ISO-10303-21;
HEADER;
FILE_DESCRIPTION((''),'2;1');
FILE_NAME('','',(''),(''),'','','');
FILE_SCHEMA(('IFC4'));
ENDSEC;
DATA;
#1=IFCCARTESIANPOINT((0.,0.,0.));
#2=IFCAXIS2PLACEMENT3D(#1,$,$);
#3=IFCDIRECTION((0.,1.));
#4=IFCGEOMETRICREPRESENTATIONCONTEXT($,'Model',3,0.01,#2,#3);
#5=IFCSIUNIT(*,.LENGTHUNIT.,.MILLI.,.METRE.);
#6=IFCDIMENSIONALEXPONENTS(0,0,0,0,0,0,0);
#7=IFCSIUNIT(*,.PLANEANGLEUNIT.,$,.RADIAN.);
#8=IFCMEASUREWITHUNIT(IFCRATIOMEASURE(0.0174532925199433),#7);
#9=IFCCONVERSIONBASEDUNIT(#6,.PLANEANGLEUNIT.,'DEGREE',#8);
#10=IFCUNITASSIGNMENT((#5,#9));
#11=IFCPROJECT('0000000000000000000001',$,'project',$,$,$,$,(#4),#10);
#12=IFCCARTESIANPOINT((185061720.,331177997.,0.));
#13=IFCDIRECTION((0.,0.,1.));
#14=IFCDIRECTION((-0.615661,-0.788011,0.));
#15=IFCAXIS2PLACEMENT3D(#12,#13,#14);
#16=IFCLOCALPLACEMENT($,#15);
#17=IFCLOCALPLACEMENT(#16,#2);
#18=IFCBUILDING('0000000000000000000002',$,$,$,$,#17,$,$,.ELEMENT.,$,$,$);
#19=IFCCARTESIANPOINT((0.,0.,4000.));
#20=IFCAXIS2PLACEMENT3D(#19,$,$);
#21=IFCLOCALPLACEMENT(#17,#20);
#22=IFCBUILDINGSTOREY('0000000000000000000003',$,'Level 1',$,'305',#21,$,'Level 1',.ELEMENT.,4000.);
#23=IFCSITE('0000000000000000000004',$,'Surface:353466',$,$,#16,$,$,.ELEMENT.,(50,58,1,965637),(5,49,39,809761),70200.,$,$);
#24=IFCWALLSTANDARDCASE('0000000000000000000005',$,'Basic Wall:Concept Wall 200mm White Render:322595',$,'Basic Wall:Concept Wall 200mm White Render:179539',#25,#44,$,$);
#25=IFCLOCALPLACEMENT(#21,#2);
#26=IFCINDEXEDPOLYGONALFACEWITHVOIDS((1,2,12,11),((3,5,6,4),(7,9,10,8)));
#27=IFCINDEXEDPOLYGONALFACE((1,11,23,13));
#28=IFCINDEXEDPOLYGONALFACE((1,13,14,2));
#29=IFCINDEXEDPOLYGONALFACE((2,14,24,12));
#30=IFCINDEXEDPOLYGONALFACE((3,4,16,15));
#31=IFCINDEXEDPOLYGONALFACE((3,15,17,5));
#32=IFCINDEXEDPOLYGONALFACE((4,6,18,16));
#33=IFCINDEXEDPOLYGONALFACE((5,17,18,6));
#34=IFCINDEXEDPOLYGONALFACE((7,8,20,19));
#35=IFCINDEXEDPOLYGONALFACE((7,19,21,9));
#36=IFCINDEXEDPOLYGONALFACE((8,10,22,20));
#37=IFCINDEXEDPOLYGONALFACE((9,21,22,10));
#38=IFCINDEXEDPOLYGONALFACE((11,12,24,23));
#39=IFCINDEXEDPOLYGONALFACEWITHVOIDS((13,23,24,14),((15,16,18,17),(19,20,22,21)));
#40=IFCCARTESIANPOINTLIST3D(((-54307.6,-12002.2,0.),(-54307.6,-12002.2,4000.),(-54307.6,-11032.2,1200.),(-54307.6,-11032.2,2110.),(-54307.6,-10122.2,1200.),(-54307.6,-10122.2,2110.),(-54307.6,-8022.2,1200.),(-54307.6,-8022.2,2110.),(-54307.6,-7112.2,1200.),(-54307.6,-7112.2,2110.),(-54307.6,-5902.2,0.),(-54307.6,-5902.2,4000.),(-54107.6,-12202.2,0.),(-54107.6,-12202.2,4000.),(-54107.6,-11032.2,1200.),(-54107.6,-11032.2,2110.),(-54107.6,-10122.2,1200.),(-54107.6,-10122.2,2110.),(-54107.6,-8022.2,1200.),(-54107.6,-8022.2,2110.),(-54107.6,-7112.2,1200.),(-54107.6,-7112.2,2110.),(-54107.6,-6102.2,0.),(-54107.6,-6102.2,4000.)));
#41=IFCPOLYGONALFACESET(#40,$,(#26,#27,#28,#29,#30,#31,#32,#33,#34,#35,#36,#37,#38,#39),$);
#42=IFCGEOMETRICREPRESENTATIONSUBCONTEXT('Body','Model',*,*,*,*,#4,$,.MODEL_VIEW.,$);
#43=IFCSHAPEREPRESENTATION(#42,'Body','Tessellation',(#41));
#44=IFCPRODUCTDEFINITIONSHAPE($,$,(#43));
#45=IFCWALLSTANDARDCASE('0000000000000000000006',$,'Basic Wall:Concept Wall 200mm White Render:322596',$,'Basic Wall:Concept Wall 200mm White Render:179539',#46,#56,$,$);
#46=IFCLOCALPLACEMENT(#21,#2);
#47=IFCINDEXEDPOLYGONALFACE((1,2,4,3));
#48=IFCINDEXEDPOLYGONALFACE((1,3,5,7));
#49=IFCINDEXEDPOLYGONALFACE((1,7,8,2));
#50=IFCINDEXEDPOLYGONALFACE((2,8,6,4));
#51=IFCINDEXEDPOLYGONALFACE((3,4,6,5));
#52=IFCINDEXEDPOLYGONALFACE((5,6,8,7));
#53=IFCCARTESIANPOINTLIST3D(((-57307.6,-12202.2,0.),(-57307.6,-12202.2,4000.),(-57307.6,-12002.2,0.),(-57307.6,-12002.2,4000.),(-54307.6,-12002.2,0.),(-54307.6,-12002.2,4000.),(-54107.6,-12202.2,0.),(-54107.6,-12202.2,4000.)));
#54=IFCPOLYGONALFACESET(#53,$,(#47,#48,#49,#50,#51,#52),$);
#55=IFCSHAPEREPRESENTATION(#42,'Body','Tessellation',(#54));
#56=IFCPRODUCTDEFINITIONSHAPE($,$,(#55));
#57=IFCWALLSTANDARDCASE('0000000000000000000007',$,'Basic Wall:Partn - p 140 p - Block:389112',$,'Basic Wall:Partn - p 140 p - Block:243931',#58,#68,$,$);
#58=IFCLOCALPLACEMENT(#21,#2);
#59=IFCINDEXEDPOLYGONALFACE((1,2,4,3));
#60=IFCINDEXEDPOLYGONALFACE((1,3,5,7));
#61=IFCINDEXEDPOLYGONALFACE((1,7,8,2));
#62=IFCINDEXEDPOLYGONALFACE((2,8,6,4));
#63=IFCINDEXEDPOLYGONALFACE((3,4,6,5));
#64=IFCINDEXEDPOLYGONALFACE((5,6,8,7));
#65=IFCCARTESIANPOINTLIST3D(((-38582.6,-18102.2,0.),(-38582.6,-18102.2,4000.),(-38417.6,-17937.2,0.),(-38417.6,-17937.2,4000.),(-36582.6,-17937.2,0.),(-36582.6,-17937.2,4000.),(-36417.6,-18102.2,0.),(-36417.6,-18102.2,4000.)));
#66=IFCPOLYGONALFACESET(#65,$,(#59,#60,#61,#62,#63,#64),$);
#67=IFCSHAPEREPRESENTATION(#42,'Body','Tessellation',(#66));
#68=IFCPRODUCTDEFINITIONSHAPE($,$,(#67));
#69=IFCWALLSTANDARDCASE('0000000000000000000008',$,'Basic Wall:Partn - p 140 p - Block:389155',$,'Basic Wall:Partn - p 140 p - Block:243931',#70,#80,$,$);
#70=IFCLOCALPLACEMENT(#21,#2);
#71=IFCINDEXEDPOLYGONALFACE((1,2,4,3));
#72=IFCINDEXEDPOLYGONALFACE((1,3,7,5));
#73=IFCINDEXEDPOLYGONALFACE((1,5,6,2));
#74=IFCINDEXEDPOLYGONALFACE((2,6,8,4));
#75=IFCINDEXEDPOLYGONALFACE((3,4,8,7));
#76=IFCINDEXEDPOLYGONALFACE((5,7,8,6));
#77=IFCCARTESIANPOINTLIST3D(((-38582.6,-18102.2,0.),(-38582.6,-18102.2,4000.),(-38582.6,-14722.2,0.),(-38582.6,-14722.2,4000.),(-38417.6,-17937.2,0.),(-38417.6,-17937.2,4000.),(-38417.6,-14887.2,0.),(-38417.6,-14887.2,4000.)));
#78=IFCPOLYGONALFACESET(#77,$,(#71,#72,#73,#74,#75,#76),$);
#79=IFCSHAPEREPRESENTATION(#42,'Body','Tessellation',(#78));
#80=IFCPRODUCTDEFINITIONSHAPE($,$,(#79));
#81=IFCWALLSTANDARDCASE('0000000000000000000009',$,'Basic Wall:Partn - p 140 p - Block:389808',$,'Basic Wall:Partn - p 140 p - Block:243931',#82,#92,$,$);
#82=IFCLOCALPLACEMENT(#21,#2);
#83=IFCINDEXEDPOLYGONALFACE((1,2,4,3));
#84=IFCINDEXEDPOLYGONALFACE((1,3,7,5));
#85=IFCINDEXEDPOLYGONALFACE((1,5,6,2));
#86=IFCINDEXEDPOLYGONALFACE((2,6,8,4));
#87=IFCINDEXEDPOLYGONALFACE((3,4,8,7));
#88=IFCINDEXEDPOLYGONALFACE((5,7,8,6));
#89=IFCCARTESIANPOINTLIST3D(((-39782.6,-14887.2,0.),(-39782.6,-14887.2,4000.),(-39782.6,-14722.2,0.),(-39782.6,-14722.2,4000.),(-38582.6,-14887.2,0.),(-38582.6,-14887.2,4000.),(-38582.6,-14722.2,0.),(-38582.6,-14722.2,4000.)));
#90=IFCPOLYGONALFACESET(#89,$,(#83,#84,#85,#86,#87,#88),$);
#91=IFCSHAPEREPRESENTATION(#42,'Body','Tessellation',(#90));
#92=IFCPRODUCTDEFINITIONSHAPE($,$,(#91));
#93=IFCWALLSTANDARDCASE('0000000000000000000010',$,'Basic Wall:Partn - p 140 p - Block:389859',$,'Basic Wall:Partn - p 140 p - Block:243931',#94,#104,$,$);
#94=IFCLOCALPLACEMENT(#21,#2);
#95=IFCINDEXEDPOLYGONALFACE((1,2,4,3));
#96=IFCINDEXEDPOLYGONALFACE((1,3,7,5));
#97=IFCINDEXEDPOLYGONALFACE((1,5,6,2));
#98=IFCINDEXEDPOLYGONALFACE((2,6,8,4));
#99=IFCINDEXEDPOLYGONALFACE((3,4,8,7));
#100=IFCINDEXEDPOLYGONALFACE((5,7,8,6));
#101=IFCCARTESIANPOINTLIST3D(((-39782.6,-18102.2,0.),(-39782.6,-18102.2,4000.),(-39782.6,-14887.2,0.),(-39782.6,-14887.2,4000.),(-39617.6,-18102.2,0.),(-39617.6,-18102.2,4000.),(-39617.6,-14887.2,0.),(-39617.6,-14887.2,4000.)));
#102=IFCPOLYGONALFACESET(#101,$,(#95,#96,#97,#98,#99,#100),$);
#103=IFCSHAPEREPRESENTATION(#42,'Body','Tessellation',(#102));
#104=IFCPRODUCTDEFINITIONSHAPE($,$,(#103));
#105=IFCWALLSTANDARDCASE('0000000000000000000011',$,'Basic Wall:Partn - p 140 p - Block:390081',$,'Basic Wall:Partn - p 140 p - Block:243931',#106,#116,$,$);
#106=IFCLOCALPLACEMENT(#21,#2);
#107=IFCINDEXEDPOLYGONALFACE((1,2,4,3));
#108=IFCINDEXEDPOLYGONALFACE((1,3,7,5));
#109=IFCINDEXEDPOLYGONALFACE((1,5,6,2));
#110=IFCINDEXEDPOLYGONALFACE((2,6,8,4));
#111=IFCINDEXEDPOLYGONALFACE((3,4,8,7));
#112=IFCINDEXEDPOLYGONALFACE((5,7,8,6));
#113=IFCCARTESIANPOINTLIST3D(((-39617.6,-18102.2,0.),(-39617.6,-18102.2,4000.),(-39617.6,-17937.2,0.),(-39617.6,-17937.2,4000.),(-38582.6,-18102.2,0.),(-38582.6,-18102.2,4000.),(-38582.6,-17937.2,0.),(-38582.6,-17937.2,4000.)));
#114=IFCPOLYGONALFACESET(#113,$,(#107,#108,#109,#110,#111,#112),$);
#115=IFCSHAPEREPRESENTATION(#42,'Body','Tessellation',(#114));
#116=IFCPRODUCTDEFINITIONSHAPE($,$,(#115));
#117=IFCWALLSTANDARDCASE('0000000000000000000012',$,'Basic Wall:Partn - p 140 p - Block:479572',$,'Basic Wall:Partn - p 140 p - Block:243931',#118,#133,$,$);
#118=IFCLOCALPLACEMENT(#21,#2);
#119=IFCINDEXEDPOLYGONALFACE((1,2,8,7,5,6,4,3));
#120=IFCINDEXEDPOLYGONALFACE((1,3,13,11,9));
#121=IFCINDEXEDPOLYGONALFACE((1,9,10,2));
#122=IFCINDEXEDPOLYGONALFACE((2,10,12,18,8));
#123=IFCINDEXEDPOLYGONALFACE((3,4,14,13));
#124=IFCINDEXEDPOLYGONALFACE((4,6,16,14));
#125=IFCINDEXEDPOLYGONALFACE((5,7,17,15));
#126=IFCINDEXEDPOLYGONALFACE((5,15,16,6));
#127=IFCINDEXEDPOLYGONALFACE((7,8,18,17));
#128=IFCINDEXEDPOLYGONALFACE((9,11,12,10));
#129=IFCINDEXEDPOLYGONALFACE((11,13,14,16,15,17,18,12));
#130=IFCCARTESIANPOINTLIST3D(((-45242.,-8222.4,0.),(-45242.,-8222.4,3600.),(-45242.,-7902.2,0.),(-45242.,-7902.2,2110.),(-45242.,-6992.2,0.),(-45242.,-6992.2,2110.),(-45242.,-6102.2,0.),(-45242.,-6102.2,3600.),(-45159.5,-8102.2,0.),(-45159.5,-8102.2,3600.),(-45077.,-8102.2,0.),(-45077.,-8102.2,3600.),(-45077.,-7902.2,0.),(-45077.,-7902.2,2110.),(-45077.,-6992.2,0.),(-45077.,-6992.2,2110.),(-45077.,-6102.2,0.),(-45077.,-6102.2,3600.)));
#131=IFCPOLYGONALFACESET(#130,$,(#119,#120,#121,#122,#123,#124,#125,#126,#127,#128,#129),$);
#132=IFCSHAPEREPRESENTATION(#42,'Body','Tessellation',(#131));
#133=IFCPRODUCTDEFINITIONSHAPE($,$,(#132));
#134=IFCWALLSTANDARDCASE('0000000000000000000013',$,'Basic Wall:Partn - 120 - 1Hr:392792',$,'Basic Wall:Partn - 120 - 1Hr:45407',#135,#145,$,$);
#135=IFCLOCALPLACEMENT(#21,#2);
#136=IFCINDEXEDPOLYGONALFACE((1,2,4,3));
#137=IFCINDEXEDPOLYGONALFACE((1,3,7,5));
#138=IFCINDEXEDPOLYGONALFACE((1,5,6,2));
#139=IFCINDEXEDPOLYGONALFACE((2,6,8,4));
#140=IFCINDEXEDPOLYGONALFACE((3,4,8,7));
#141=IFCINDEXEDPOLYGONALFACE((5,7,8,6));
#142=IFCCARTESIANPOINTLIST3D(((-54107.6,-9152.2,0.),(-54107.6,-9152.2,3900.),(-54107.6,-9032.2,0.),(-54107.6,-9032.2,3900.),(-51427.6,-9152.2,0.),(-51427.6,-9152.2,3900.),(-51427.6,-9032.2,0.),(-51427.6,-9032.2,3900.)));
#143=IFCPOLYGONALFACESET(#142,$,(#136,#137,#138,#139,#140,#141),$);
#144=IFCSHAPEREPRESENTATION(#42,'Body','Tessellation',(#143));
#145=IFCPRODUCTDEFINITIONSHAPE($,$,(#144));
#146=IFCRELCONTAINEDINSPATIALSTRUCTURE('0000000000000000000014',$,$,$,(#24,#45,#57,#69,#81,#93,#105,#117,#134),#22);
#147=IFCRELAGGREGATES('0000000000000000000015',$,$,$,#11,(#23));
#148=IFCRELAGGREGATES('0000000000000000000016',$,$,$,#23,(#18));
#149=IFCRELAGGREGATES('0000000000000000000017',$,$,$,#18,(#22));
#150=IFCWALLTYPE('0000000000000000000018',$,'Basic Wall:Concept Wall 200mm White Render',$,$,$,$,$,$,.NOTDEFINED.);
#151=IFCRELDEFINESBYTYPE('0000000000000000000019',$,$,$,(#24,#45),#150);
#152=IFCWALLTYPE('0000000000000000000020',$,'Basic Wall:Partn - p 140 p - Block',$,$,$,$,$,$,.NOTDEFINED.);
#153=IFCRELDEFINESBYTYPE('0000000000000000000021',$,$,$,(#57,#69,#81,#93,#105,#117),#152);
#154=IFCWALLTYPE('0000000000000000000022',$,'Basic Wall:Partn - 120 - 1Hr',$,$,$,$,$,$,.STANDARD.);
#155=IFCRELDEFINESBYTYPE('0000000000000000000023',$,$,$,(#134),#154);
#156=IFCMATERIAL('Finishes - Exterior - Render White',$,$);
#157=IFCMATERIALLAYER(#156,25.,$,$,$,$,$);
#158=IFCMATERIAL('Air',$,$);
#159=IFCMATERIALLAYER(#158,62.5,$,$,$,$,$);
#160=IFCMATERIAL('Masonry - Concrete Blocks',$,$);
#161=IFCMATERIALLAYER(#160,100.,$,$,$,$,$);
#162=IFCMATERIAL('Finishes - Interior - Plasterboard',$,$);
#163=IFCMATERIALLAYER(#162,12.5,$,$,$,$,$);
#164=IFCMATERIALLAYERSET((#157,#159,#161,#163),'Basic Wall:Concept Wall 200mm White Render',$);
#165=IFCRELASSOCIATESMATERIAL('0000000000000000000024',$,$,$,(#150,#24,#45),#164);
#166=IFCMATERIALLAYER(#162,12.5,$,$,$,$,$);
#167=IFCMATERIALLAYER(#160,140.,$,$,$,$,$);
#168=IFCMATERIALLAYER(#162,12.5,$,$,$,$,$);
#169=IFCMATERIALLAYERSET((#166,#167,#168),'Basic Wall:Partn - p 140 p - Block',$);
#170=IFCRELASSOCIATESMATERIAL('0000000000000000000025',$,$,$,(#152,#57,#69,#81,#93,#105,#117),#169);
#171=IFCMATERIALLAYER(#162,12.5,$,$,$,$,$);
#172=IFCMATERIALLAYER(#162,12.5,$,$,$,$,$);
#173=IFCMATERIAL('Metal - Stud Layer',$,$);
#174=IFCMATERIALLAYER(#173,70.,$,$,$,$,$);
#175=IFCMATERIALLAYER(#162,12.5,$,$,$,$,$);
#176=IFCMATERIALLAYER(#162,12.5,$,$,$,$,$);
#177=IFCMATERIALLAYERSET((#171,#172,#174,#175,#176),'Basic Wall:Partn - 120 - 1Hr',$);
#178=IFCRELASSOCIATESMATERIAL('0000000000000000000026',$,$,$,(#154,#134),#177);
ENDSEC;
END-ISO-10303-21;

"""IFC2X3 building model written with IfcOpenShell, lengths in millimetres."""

from ifc_helpers import new_model, entity, si_unit, converted_unit, direction, frame, frame_2d, origin, place, context, subcontext, project, spatial, polyline, rectangle, outline, extrude, clip, halfspace, bounded_halfspace, material, layer, layer_set, layer_usage, type_object, element, save


model = new_model("IFC2X3")

# Units and contexts
model_context = context("Model", 3, precision=0.01, world=origin(), true_north=direction((0.0, 1.0)))
body_context = subcontext(model_context, "Body", "Model", "MODEL_VIEW")
ifc_project = project(units=[si_unit("LENGTHUNIT", "METRE", prefix="MILLI"), converted_unit("PLANEANGLEUNIT", "DEGREE", entity("IfcRatioMeasure", 0.0174532925199433), si_unit("PLANEANGLEUNIT", "RADIAN"), dimensions=[0, 0, 0, 0, 0, 0, 0])], contexts=[model_context])

# Site, building, storey
site_placement = place(None, frame((185061720.0, 331177997.0, 0.0), z_axis=(0.0, 0.0, 1.0), x_axis=(-0.615661, -0.788011, 0.0)))
site = spatial("IfcSite", under=ifc_project, at=site_placement, Name="Surface:353466", CompositionType="ELEMENT", RefLatitude=(50, 58, 1, 965637), RefLongitude=(5, 49, 39, 809761), RefElevation=70200.0)
building_placement = place(site_placement, origin())
building = spatial("IfcBuilding", under=site, at=building_placement, CompositionType="ELEMENT")
storey_placement = place(building_placement, frame((0.0, 0.0, 4000.0)))
storey = spatial("IfcBuildingStorey", under=building, at=storey_placement, Name="Level 1", ObjectType="305", LongName="Level 1", CompositionType="ELEMENT", Elevation=4000.0)

# Wall, openings
ifc_material_1 = material(Name="Finishes - Exterior - Render White")
ifc_layer_1 = layer(ifc_material_1, 25.0)
ifc_material_2 = material(Name="Air")
ifc_layer_2 = layer(ifc_material_2, 62.5)
ifc_material_3 = material(Name="Masonry - Concrete Blocks")
ifc_layer_3 = layer(ifc_material_3, 100.0)
ifc_material_4 = material(Name="Finishes - Interior - Plasterboard")
ifc_layer_4 = layer(ifc_material_4, 12.5)
ifc_layer_set_1 = layer_set([ifc_layer_1, ifc_layer_2, ifc_layer_3, ifc_layer_4], Name="Basic Wall:Concept Wall 200mm White Render")
ifc_layer_usage_1 = layer_usage(ifc_layer_set_1, "AXIS2", "POSITIVE", -100.0)
wall_type_1 = type_object("IfcWallType", Name="Basic Wall:Concept Wall 200mm White Render", PredefinedType="NOTDEFINED", material=ifc_layer_set_1)
wall_1_placement = place(storey_placement, frame((-54207.6, -5902.2, 0.0), z_axis=(0.0, 0.0, 1.0), x_axis=(0.0, -1.0, 0.0)))
wall_1 = element("IfcWallStandardCase", 1, at=wall_1_placement, inside=storey, type_object=wall_type_1, material=ifc_layer_usage_1, Name="Basic Wall:Concept Wall 200mm White Render:322595", ObjectType="Basic Wall:Concept Wall 200mm White Render:179539", context=body_context, shape_type="Clipping", body=[
    clip(extrude(outline(polyline([(6100.0, -100.0), (6300.0, 100.0), (6135.0, 100.0), (200.0, 100.0), (0.0, -100.0), (6100.0, -100.0)])), origin(), (0.0, 0.0, 1.0), 4000.0), halfspace(frame((0.0, 0.0, -4000.0)), True)),
])
opening_1_placement = place(wall_1_placement, origin())
element("IfcOpeningElement", 2, at=opening_1_placement, cuts=wall_1, ObjectType="Opening", context=body_context, shape_type="SweptSolid", body=[
    extrude(rectangle(XDim=910.0, YDim=910.0, at=frame_2d((0.0, 0.0), x_axis=(1.0, 0.0))), frame((1665.0, -1424.0, 1655.0), z_axis=(0.0, 1.0, 0.0), x_axis=(0.0, 0.0, -1.0)), (0.0, 0.0, 1.0), 3048.0),
])
opening_2_placement = place(wall_1_placement, origin())
element("IfcOpeningElement", 3, at=opening_2_placement, cuts=wall_1, ObjectType="Opening", context=body_context, shape_type="SweptSolid", body=[
    extrude(rectangle(XDim=910.0, YDim=910.0, at=frame_2d((0.0, 0.0), x_axis=(1.0, 0.0))), frame((4675.0, -1424.0, 1655.0), z_axis=(0.0, 1.0, 0.0), x_axis=(0.0, 0.0, -1.0)), (0.0, 0.0, 1.0), 3048.0),
])
opening_3_placement = place(wall_1_placement, frame((2120.0, 100.0, 1200.0)))
element("IfcOpeningElement", 4, at=opening_3_placement, cuts=wall_1, ObjectType="Opening", context=body_context, shape_type="SweptSolid", body=[
    extrude(rectangle(XDim=910.0, YDim=910.0, at=frame_2d((455.0, 455.0), x_axis=(-1.0, 0.0))), frame((0.0, 0.0, 0.0), z_axis=(0.0, -1.0, 0.0), x_axis=(0.0, 0.0, 1.0)), (0.0, 0.0, 1.0), 200.0),
])
opening_4_placement = place(wall_1_placement, frame((5130.0, 100.0, 1200.0)))
element("IfcOpeningElement", 5, at=opening_4_placement, cuts=wall_1, ObjectType="Opening", context=body_context, shape_type="SweptSolid", body=[
    extrude(rectangle(XDim=910.0, YDim=910.0, at=frame_2d((455.0, 455.0), x_axis=(-1.0, 0.0))), frame((0.0, 0.0, 0.0), z_axis=(0.0, -1.0, 0.0), x_axis=(0.0, 0.0, 1.0)), (0.0, 0.0, 1.0), 200.0),
])

# Walls
ifc_layer_usage_2 = layer_usage(ifc_layer_set_1, "AXIS2", "POSITIVE", -100.0)
wall_2_placement = place(storey_placement, frame((-54107.6, -12102.2, 0.0), z_axis=(0.0, 0.0, 1.0), x_axis=(-1.0, 0.0, 0.0)))
element("IfcWallStandardCase", 6, at=wall_2_placement, inside=storey, type_object=wall_type_1, material=ifc_layer_usage_2, Name="Basic Wall:Concept Wall 200mm White Render:322596", ObjectType="Basic Wall:Concept Wall 200mm White Render:179539", context=body_context, shape_type="Clipping", body=[
    clip(extrude(outline(polyline([(200.0, -100.0), (3200.0, -100.0), (3200.0, 100.0), (0.0, 100.0), (200.0, -100.0)])), origin(), (0.0, 0.0, 1.0), 4000.0), halfspace(frame((0.0, 0.0, -4000.0)), True)),
])
ifc_layer_5 = layer(ifc_material_4, 12.5)
ifc_layer_6 = layer(ifc_material_3, 140.0)
ifc_layer_7 = layer(ifc_material_4, 12.5)
ifc_layer_set_2 = layer_set([ifc_layer_5, ifc_layer_6, ifc_layer_7], Name="Basic Wall:Partn - p 140 p - Block")
ifc_layer_usage_3 = layer_usage(ifc_layer_set_2, "AXIS2", "NEGATIVE", 82.5)
wall_type_2 = type_object("IfcWallType", Name="Basic Wall:Partn - p 140 p - Block", PredefinedType="NOTDEFINED", material=ifc_layer_set_2)
wall_3_placement = place(storey_placement, frame((-36417.6, -18019.7, 0.0), z_axis=(0.0, 0.0, 1.0), x_axis=(-1.0, 0.0, 0.0)))
element("IfcWallStandardCase", 7, at=wall_3_placement, inside=storey, type_object=wall_type_2, material=ifc_layer_usage_3, Name="Basic Wall:Partn - p 140 p - Block:389112", ObjectType="Basic Wall:Partn - p 140 p - Block:243931", context=body_context, shape_type="Clipping", body=[
    clip(extrude(outline(polyline([(2000.0, -82.5), (2165.0, 82.5), (0.0, 82.5), (165.0, -82.5), (2000.0, -82.5)])), origin(), (0.0, 0.0, 1.0), 4000.0), halfspace(frame((0.0, 0.0, -4000.0)), True)),
])
ifc_layer_usage_4 = layer_usage(ifc_layer_set_2, "AXIS2", "NEGATIVE", 82.5)
wall_4_placement = place(storey_placement, frame((-38500.1, -18102.2, 0.0), z_axis=(0.0, 0.0, 1.0), x_axis=(0.0, 1.0, 0.0)))
element("IfcWallStandardCase", 8, at=wall_4_placement, inside=storey, type_object=wall_type_2, material=ifc_layer_usage_4, Name="Basic Wall:Partn - p 140 p - Block:389155", ObjectType="Basic Wall:Partn - p 140 p - Block:243931", context=body_context, shape_type="Clipping", body=[
    clip(extrude(outline(polyline([(3215.0, -82.5), (3380.0, 82.5), (0.0, 82.5), (165.0, -82.5), (3215.0, -82.5)])), origin(), (0.0, 0.0, 1.0), 4000.0), halfspace(frame((0.0, 0.0, -4000.0)), True)),
])
ifc_layer_usage_5 = layer_usage(ifc_layer_set_2, "AXIS2", "POSITIVE", -82.5)
wall_5_placement = place(storey_placement, frame((-38582.6, -14804.7, 0.0), z_axis=(0.0, 0.0, 1.0), x_axis=(-1.0, 0.0, 0.0)))
element("IfcWallStandardCase", 9, at=wall_5_placement, inside=storey, type_object=wall_type_2, material=ifc_layer_usage_5, Name="Basic Wall:Partn - p 140 p - Block:389808", ObjectType="Basic Wall:Partn - p 140 p - Block:243931", context=body_context, shape_type="Clipping", body=[
    clip(extrude(rectangle(XDim=1200.0, YDim=165.0, at=frame_2d((600.0, 0.0), x_axis=(-1.0, 0.0))), origin(), (0.0, 0.0, 1.0), 4000.0), halfspace(origin(), True)),
])
ifc_layer_usage_6 = layer_usage(ifc_layer_set_2, "AXIS2", "POSITIVE", -82.5)
wall_6_placement = place(storey_placement, frame((-39700.1, -14887.2, 0.0), z_axis=(0.0, 0.0, 1.0), x_axis=(0.0, -1.0, 0.0)))
element("IfcWallStandardCase", 10, at=wall_6_placement, inside=storey, type_object=wall_type_2, material=ifc_layer_usage_6, Name="Basic Wall:Partn - p 140 p - Block:389859", ObjectType="Basic Wall:Partn - p 140 p - Block:243931", context=body_context, shape_type="Clipping", body=[
    clip(extrude(rectangle(XDim=3215.0, YDim=165.0, at=frame_2d((1607.5, 0.0), x_axis=(-1.0, 0.0))), origin(), (0.0, 0.0, 1.0), 4000.0), halfspace(origin(), True)),
])
ifc_layer_usage_7 = layer_usage(ifc_layer_set_2, "AXIS2", "POSITIVE", -82.5)
wall_7_placement = place(storey_placement, frame((-39617.6, -18019.7, 0.0)))
element("IfcWallStandardCase", 11, at=wall_7_placement, inside=storey, type_object=wall_type_2, material=ifc_layer_usage_7, Name="Basic Wall:Partn - p 140 p - Block:390081", ObjectType="Basic Wall:Partn - p 140 p - Block:243931", context=body_context, shape_type="Clipping", body=[
    clip(extrude(rectangle(XDim=1035.0, YDim=165.0, at=frame_2d((517.5, 0.0), x_axis=(-1.0, 0.0))), origin(), (0.0, 0.0, 1.0), 4000.0), halfspace(origin(), True)),
])

# Wall, openings
ifc_layer_usage_8 = layer_usage(ifc_layer_set_2, "AXIS2", "NEGATIVE", 82.5)
wall_8_placement = place(storey_placement, frame((-45159.5, -8222.4, 0.0), z_axis=(0.0, 0.0, 1.0), x_axis=(0.0, 1.0, 0.0)))
wall_8 = element("IfcWallStandardCase", 12, at=wall_8_placement, inside=storey, type_object=wall_type_2, material=ifc_layer_usage_8, Name="Basic Wall:Partn - p 140 p - Block:479572", ObjectType="Basic Wall:Partn - p 140 p - Block:243931", context=body_context, shape_type="Clipping", body=[
    clip(extrude(outline(polyline([(120.1, -82.5), (2120.1, -82.5), (2120.1, 82.5), (0.0, 82.5), (120.1, 0.0), (120.1, -82.5)])), origin(), (0.0, 0.0, 1.0), 3600.0), bounded_halfspace(frame((120.1, -82.5, 3600.0), z_axis=(0.0, 0.0, -1.0), x_axis=(0.0, -1.0, 0.0)), True, frame((120.1, -82.5, 3600.0)), polyline([(0.0, 0.0), (2000.0, 0.0), (2000.0, 165.0), (-120.1, 165.0), (0.0, 82.5), (0.0, 0.0)]))),
])
opening_5_placement = place(wall_8_placement, origin())
element("IfcOpeningElement", 13, at=opening_5_placement, cuts=wall_8, ObjectType="Opening", context=body_context, shape_type="SweptSolid", body=[
    extrude(rectangle(XDim=2110.0, YDim=910.0, at=frame_2d((0.0, 0.0), x_axis=(1.0, 0.0))), frame((775.1, -1441.5, 1055.0), z_axis=(0.0, 1.0, 0.0), x_axis=(0.0, 0.0, 1.0)), (0.0, 0.0, 1.0), 3048.0),
])
opening_6_placement = place(wall_8_placement, frame((1230.1, 82.5, 0.0)))
element("IfcOpeningElement", 14, at=opening_6_placement, cuts=wall_8, ObjectType="Opening", context=body_context, shape_type="SweptSolid", body=[
    extrude(rectangle(XDim=2110.0, YDim=910.0, at=frame_2d((1055.0, 455.0), x_axis=(1.0, 0.0))), frame((0.0, 0.0, 0.0), z_axis=(0.0, -1.0, 0.0), x_axis=(0.0, 0.0, 1.0)), (0.0, 0.0, 1.0), 165.0),
])

# Wall
ifc_layer_8 = layer(ifc_material_4, 12.5)
ifc_layer_9 = layer(ifc_material_4, 12.5)
ifc_material_5 = material(Name="Metal - Stud Layer")
ifc_layer_10 = layer(ifc_material_5, 70.0)
ifc_layer_11 = layer(ifc_material_4, 12.5)
ifc_layer_12 = layer(ifc_material_4, 12.5)
ifc_layer_set_3 = layer_set([ifc_layer_8, ifc_layer_9, ifc_layer_10, ifc_layer_11, ifc_layer_12], Name="Basic Wall:Partn - 120 - 1Hr")
ifc_layer_usage_9 = layer_usage(ifc_layer_set_3, "AXIS2", "NEGATIVE", 60.0)
wall_type_3 = type_object("IfcWallType", Name="Basic Wall:Partn - 120 - 1Hr", PredefinedType="STANDARD", material=ifc_layer_set_3)
wall_9_placement = place(storey_placement, frame((-54107.6, -9092.2, 0.0)))
element("IfcWallStandardCase", 15, at=wall_9_placement, inside=storey, type_object=wall_type_3, material=ifc_layer_usage_9, Name="Basic Wall:Partn - 120 - 1Hr:392792", ObjectType="Basic Wall:Partn - 120 - 1Hr:45407", context=body_context, shape_type="Clipping", body=[
    clip(extrude(rectangle(XDim=2680.0, YDim=120.0, at=frame_2d((1340.0, 0.0), x_axis=(-1.0, 0.0))), origin(), (0.0, 0.0, 1.0), 3900.0), bounded_halfspace(frame((0.0, -60.0, 3900.0), z_axis=(0.0, 0.0, -1.0), x_axis=(0.0, -1.0, 0.0)), True, frame((0.0, -60.0, 3900.0)), polyline([(0.0, 0.0), (2680.0, 0.0), (2680.0, 120.0), (0.0, 120.0), (0.0, 0.0)]))),
])

save(model, "model.ifc")
